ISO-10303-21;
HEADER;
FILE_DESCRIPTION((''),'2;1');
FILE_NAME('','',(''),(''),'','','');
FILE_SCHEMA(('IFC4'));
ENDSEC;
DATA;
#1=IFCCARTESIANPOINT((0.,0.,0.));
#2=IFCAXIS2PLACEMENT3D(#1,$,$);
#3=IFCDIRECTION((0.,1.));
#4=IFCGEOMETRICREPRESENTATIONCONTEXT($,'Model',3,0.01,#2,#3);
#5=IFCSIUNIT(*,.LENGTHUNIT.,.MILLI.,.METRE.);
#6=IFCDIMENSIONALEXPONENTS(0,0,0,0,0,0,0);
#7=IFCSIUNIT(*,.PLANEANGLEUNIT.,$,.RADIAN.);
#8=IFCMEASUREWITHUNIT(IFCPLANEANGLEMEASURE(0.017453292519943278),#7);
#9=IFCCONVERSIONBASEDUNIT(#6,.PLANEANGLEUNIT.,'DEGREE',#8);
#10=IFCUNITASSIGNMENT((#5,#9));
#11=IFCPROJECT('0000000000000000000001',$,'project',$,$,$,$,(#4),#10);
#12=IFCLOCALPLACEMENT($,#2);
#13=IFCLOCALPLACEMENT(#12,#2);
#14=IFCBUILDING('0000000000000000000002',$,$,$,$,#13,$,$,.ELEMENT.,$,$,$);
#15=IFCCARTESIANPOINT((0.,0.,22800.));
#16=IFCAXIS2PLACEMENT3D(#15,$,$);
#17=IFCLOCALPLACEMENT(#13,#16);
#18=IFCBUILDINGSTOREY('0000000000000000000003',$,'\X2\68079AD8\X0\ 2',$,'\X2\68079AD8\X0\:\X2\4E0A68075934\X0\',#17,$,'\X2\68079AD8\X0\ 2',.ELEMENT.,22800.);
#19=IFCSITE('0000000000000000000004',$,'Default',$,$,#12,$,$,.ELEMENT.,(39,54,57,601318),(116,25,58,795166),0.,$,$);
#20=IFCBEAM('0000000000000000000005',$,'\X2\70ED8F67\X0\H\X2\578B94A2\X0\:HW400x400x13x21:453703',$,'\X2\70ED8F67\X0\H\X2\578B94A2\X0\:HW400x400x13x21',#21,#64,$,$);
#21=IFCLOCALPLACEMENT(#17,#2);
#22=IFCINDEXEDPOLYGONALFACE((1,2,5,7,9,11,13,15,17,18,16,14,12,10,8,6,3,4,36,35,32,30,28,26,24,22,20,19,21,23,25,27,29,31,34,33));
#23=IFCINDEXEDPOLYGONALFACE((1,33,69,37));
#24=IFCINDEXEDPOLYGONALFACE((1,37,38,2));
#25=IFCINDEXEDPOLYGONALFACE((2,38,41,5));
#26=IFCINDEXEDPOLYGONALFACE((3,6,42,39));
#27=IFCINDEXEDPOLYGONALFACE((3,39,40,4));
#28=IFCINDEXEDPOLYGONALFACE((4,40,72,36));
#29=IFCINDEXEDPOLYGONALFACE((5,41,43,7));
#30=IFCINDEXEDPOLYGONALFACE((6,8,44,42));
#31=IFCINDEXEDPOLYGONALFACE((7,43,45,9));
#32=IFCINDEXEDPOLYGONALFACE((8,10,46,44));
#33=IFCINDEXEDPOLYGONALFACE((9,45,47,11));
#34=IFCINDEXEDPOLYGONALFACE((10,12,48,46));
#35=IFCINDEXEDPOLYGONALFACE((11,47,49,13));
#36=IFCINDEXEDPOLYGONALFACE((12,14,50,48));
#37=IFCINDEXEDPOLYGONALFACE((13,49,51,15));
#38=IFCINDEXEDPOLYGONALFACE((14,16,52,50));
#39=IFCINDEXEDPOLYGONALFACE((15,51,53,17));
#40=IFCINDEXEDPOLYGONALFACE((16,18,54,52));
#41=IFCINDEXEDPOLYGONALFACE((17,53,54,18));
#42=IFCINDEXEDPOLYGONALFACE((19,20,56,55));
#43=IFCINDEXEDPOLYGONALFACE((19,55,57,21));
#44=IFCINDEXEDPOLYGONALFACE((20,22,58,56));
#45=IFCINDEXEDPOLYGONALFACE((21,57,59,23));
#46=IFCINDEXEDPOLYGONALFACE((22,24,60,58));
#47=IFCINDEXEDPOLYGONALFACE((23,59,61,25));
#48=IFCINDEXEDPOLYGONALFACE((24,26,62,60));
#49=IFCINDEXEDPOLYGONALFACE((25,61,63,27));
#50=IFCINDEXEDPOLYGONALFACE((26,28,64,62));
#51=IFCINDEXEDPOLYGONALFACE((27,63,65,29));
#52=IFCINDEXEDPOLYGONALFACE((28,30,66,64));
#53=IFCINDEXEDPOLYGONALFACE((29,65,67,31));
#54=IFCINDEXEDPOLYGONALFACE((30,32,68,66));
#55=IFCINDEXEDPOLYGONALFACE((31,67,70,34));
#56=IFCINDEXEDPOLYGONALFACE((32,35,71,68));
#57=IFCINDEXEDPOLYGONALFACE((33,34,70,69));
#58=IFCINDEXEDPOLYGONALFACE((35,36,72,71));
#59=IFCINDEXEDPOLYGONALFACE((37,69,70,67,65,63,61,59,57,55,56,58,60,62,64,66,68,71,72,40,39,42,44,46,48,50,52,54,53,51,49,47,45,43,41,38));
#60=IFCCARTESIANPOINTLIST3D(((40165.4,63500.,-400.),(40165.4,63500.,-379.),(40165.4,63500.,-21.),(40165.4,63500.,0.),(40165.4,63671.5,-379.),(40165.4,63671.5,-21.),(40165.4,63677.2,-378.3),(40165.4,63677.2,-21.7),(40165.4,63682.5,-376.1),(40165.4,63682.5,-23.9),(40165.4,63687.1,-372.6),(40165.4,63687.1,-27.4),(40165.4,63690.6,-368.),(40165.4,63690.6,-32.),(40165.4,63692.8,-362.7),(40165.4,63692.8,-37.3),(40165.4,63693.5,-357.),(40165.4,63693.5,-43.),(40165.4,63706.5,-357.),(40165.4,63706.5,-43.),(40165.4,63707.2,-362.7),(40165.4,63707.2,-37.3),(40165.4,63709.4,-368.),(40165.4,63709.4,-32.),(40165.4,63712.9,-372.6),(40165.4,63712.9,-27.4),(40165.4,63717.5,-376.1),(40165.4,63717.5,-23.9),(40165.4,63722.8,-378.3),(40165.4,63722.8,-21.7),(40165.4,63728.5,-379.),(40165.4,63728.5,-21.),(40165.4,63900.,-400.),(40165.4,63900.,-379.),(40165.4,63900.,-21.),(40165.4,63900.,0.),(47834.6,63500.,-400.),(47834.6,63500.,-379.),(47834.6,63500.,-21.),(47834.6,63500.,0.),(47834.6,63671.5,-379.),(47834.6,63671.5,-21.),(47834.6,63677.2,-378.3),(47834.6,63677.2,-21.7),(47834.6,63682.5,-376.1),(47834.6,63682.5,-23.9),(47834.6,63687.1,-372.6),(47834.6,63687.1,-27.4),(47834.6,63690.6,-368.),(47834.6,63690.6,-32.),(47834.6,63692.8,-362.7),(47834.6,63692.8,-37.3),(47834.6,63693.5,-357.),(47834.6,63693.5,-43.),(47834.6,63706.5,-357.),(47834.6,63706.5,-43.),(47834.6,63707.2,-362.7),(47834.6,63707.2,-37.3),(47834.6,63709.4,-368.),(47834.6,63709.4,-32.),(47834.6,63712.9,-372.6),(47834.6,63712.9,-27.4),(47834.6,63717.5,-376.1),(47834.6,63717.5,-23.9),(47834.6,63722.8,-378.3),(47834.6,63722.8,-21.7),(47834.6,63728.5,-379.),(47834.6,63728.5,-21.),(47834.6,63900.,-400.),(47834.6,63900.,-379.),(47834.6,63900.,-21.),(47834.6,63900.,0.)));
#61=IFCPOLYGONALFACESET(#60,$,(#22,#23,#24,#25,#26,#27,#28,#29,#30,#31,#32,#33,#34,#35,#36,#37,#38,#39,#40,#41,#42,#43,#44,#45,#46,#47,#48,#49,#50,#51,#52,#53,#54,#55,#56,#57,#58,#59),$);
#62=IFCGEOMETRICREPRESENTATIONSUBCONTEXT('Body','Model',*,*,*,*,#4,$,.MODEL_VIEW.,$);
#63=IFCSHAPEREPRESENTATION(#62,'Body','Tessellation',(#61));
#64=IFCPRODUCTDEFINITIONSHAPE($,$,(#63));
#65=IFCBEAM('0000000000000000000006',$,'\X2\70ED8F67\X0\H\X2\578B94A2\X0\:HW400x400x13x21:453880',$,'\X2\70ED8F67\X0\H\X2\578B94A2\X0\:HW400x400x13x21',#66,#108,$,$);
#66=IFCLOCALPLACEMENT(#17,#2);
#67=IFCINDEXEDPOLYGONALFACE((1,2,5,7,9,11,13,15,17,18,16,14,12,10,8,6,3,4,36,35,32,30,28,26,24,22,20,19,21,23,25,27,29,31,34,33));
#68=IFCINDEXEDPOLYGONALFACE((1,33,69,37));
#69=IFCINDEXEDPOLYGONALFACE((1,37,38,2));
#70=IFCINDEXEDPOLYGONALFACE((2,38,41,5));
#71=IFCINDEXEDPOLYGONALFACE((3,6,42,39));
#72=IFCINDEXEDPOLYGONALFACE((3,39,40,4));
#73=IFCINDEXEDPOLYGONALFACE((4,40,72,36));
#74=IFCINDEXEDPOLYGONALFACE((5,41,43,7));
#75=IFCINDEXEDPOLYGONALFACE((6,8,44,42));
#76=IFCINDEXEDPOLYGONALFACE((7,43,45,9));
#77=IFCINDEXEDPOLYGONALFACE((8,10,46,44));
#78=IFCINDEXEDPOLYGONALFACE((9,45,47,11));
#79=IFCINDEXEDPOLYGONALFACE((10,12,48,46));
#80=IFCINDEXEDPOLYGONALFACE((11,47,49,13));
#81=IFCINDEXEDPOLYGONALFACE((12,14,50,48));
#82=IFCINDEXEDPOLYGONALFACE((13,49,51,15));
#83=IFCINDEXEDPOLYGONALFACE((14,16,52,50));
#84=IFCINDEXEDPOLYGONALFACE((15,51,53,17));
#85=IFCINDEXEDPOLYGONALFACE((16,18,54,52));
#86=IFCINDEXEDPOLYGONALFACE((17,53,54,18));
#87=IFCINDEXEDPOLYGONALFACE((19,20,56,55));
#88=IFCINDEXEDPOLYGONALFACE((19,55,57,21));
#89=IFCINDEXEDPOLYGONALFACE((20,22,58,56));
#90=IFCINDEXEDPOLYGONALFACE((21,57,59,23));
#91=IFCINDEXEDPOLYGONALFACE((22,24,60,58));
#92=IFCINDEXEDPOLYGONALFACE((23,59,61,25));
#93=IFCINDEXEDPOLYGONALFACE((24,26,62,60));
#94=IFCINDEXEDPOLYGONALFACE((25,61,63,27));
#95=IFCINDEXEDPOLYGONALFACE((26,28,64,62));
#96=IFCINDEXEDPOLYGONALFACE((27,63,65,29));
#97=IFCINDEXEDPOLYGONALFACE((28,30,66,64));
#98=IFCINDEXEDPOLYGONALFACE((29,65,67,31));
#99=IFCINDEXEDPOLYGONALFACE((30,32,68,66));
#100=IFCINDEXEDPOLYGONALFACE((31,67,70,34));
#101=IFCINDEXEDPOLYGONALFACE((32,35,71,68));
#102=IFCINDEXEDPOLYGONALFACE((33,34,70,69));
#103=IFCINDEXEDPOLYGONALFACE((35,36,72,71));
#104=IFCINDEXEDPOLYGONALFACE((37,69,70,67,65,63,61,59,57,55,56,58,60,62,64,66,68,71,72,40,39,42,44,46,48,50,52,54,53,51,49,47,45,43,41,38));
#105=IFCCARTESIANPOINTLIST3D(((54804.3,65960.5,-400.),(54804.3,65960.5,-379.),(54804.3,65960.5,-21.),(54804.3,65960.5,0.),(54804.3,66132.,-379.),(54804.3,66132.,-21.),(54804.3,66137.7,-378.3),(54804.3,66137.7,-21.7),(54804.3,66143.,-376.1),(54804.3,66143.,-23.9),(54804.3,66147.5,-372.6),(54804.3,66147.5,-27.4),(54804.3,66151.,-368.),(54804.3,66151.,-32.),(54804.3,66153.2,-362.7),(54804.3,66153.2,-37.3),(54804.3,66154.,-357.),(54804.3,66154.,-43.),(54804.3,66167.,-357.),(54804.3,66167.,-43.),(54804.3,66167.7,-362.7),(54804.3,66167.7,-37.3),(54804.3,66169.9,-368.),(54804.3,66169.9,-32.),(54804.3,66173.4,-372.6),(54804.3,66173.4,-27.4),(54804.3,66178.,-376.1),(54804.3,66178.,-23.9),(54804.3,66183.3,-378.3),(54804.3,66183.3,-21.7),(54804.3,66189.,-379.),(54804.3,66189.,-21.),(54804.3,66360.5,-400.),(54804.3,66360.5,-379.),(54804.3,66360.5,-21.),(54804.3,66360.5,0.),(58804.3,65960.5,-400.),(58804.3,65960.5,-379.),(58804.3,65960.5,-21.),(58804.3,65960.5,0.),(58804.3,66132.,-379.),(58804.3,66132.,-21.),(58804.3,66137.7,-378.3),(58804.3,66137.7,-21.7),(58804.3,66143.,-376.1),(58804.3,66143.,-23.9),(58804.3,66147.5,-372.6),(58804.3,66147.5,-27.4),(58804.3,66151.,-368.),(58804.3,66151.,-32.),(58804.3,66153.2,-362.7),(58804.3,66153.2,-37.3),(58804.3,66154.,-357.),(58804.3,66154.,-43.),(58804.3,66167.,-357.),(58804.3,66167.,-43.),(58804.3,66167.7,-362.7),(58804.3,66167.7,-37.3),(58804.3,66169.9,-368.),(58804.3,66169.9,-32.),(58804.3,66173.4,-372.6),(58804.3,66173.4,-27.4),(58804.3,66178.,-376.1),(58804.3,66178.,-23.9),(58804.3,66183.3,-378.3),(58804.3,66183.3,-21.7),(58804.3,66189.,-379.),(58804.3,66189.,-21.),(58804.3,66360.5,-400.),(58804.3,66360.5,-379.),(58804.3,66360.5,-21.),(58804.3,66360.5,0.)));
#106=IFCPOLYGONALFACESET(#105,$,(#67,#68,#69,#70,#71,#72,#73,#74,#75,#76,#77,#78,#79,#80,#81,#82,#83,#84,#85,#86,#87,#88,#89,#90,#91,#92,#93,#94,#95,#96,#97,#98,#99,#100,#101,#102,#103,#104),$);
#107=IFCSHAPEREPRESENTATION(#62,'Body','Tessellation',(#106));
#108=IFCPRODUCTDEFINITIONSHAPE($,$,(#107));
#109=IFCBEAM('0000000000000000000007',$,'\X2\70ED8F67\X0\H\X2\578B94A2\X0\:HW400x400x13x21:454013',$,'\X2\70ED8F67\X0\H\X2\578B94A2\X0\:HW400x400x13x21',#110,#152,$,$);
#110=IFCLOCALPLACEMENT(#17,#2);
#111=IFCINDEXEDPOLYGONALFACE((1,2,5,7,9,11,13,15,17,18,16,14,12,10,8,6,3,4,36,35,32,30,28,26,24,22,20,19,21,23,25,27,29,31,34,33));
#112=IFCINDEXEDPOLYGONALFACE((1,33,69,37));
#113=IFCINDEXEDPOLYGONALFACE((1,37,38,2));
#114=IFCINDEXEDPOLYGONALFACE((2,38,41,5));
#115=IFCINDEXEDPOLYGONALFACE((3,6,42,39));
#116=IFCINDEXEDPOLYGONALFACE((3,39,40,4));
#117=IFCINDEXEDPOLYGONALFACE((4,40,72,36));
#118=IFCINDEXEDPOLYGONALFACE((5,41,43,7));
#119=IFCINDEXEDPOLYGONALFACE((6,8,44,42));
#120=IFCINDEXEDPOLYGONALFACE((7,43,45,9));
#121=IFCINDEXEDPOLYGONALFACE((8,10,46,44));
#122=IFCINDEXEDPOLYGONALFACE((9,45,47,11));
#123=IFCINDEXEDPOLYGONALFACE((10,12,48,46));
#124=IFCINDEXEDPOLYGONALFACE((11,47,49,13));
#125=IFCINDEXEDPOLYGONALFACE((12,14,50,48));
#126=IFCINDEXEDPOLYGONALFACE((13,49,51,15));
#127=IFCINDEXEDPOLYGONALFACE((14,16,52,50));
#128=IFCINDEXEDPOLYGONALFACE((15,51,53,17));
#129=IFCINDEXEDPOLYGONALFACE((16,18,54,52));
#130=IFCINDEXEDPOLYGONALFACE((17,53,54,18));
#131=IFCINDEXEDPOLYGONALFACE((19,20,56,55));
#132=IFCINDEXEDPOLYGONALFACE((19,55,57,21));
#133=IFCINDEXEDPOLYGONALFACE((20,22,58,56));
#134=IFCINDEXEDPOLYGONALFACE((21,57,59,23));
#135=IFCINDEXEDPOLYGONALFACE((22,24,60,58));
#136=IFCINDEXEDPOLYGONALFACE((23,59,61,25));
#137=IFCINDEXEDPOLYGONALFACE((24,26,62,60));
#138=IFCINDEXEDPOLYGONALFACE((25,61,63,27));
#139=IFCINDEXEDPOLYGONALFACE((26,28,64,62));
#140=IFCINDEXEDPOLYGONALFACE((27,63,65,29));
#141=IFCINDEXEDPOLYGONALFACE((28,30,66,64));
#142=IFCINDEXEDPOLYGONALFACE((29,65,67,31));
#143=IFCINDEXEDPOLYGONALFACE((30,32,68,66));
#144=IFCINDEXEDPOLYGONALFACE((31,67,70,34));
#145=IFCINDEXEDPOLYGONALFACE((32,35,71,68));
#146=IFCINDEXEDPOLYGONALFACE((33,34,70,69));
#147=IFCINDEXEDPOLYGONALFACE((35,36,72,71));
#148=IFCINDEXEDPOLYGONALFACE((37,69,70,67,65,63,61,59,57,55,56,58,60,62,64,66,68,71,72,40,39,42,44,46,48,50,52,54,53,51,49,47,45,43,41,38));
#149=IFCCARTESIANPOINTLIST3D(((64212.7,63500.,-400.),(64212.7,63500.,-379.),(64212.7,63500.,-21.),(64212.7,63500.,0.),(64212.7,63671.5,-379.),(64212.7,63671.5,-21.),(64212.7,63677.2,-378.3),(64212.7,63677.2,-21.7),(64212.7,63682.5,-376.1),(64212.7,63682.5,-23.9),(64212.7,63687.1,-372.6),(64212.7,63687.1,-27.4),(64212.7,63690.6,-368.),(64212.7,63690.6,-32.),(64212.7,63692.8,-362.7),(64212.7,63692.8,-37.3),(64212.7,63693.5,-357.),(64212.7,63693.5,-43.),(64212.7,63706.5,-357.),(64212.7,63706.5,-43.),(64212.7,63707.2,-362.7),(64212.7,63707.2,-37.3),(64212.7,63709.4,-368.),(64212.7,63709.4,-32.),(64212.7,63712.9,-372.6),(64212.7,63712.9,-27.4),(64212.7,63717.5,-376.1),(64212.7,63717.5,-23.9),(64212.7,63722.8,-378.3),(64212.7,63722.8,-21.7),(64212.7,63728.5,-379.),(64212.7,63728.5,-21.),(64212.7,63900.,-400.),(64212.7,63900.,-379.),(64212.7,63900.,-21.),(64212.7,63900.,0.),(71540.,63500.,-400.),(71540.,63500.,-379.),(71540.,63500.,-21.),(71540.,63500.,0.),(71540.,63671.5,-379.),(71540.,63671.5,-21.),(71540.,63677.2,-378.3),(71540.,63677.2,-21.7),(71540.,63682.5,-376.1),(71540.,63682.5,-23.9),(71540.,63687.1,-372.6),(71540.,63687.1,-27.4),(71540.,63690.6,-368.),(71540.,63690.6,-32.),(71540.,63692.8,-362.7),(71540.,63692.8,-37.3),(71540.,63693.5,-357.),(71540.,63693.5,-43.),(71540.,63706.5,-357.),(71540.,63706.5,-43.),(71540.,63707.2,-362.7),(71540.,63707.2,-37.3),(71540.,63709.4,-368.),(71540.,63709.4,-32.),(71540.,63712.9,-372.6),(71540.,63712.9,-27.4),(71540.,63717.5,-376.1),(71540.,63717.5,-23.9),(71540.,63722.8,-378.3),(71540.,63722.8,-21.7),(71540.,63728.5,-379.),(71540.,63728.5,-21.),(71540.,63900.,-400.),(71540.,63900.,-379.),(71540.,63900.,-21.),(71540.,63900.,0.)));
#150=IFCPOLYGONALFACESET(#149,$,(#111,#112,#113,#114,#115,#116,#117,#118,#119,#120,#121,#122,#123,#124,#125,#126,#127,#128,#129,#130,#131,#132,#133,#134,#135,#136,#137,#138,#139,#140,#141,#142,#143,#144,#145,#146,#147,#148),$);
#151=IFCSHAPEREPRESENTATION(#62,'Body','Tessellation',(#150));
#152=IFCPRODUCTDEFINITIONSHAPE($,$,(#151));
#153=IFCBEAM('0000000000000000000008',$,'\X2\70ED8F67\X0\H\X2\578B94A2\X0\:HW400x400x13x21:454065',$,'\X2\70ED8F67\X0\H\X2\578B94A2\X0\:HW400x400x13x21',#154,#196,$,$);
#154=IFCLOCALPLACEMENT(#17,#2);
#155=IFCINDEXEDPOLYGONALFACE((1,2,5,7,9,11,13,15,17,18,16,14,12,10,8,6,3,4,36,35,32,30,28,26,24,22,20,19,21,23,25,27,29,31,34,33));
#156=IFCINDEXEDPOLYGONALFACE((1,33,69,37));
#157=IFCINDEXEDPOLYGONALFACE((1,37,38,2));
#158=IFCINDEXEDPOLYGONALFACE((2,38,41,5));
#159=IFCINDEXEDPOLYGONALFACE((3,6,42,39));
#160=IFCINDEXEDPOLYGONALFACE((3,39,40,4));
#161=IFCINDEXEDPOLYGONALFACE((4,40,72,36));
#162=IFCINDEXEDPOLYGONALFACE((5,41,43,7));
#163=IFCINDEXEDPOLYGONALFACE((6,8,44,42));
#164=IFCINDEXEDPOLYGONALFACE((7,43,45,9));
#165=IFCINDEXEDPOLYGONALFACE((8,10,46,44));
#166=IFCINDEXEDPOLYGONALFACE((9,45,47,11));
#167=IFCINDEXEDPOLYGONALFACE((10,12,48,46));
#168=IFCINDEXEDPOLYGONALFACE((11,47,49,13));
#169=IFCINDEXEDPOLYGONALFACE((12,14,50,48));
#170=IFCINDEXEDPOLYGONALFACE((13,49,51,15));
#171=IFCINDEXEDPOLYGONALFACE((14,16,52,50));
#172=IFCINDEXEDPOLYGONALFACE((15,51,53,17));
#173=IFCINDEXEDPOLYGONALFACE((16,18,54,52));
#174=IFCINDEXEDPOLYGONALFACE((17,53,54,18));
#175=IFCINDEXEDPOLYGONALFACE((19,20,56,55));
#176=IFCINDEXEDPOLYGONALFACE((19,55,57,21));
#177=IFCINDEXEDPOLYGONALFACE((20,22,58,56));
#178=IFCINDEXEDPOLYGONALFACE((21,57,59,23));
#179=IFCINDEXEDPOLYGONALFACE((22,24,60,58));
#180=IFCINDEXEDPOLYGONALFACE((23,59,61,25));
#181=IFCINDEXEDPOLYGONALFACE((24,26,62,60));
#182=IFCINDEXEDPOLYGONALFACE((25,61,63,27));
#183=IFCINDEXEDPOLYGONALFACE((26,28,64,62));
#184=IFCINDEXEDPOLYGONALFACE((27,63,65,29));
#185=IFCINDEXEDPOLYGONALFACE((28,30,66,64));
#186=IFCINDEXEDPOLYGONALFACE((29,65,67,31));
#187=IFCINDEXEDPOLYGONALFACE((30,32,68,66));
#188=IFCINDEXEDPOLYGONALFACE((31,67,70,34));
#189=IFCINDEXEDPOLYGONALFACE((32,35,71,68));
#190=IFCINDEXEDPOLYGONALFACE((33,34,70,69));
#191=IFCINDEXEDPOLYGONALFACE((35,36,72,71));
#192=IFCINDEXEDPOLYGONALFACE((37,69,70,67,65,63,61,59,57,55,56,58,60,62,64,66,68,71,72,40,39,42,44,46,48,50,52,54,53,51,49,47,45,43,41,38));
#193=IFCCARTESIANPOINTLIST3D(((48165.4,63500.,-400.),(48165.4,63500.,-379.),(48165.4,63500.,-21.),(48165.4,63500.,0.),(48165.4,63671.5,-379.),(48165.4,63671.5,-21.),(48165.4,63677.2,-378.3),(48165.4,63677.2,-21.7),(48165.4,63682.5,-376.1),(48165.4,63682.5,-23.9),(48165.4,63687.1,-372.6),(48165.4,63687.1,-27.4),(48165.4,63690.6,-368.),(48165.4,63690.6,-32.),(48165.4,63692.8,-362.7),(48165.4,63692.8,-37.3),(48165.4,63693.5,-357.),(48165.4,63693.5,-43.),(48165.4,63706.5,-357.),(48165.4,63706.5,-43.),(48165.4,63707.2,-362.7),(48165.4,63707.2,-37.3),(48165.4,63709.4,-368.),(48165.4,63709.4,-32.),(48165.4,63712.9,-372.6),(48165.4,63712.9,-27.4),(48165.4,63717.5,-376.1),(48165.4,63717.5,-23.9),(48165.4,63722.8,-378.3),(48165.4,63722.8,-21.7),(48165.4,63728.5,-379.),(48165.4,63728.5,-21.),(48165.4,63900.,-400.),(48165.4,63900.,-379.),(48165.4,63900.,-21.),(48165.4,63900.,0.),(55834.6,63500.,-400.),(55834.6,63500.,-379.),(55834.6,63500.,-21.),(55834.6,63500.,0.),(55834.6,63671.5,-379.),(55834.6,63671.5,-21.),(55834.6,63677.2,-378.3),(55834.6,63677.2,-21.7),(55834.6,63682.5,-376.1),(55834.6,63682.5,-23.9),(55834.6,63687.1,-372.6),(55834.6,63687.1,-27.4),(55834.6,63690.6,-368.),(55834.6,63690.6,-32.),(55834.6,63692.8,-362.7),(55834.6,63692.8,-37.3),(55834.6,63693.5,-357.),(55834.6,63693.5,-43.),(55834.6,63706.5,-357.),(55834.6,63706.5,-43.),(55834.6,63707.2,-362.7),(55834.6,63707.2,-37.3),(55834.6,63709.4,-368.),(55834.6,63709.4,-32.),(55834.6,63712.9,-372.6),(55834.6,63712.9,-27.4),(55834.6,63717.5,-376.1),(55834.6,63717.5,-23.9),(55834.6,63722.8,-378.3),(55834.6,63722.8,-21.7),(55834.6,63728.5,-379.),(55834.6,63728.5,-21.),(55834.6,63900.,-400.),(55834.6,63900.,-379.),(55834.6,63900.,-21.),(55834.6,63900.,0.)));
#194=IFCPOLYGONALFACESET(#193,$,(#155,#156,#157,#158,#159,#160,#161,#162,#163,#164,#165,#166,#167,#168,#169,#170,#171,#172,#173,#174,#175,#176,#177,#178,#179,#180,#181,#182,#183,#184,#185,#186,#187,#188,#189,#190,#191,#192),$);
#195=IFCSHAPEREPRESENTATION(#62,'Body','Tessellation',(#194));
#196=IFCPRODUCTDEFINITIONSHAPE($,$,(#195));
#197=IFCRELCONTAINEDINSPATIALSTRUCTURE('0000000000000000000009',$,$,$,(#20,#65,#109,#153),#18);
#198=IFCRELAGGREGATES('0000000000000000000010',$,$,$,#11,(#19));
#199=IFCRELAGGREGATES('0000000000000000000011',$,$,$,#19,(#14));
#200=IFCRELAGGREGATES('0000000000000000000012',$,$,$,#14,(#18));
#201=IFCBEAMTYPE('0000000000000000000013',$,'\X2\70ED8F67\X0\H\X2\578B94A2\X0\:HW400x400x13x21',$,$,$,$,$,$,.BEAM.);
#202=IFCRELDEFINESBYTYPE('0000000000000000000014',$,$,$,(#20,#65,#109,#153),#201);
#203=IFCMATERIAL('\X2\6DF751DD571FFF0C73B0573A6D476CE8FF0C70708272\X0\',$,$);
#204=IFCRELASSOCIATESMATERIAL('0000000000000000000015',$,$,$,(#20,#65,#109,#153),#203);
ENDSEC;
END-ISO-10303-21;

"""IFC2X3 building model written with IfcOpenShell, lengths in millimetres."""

from ifc_helpers import new_model, entity, si_unit, converted_unit, direction, frame, frame_2d, origin, place, context, subcontext, project, spatial, i_section, extrude, material, type_object, element, save


model = new_model("IFC2X3")

# Units and contexts
model_context = context("Model", 3, precision=0.01, world=origin(), true_north=direction((0.0, 1.0)))
body_context = subcontext(model_context, "Body", "Model", "MODEL_VIEW")
ifc_project = project(units=[si_unit("LENGTHUNIT", "METRE", prefix="MILLI"), converted_unit("PLANEANGLEUNIT", "DEGREE", entity("IfcPlaneAngleMeasure", 0.017453292519943278), si_unit("PLANEANGLEUNIT", "RADIAN"), dimensions=[0, 0, 0, 0, 0, 0, 0])], contexts=[model_context])

# Site, building, storey
site_placement = place(None, origin())
site = spatial("IfcSite", under=ifc_project, at=site_placement, Name="Default", CompositionType="ELEMENT", RefLatitude=(39, 54, 57, 601318), RefLongitude=(116, 25, 58, 795166), RefElevation=0.0)
building_placement = place(site_placement, origin())
building = spatial("IfcBuilding", under=site, at=building_placement, CompositionType="ELEMENT")
storey_placement = place(building_placement, frame((0.0, 0.0, 22800.0)))
storey = spatial("IfcBuildingStorey", under=building, at=storey_placement, Name="标高 2", ObjectType="标高:上标头", LongName="标高 2", CompositionType="ELEMENT", Elevation=22800.0)

# Beams
ifc_material = material(Name="混凝土，现场浇注，灰色")
beam_type = type_object("IfcBeamType", Name="热轧H型钢:HW400x400x13x21", PredefinedType="BEAM")
beam_1_placement = place(storey_placement, frame((48000.0, 63700.0, 0.0), z_axis=(0.0, 0.0, 1.0), x_axis=(-1.0, 0.0, 0.0)))
element("IfcBeam", 1, at=beam_1_placement, inside=storey, type_object=beam_type, material=ifc_material, Name="热轧H型钢:HW400x400x13x21:453703", ObjectType="热轧H型钢:HW400x400x13x21", context=body_context, shape_type="SweptSolid", body=[
    extrude(i_section(OverallWidth=400.0, OverallDepth=400.0, WebThickness=13.0, FlangeThickness=21.0, FilletRadius=22.0, at=frame_2d((0.0, 0.0), x_axis=(0.0, 1.0))), frame((165.4, 0.0, -200.0), z_axis=(1.0, 0.0, 0.0), x_axis=(0.0, 0.0, -1.0)), (0.0, 0.0, 1.0), 7669.2),
])
beam_2_placement = place(storey_placement, frame((54804.3, 66160.5, 0.0)))
element("IfcBeam", 2, at=beam_2_placement, inside=storey, type_object=beam_type, material=ifc_material, Name="热轧H型钢:HW400x400x13x21:453880", ObjectType="热轧H型钢:HW400x400x13x21", context=body_context, shape_type="SweptSolid", body=[
    extrude(i_section(OverallWidth=400.0, OverallDepth=400.0, WebThickness=13.0, FlangeThickness=21.0, FilletRadius=22.0, at=frame_2d((0.0, 0.0), x_axis=(0.0, 1.0))), frame((0.0, 0.0, -200.0), z_axis=(1.0, 0.0, 0.0), x_axis=(0.0, 0.0, -1.0)), (0.0, 0.0, 1.0), 4000.0),
])
beam_3_placement = place(storey_placement, frame((64000.0, 63700.0, 0.0)))
element("IfcBeam", 3, at=beam_3_placement, inside=storey, type_object=beam_type, material=ifc_material, Name="热轧H型钢:HW400x400x13x21:454013", ObjectType="热轧H型钢:HW400x400x13x21", context=body_context, shape_type="SweptSolid", body=[
    extrude(i_section(OverallWidth=400.0, OverallDepth=400.0, WebThickness=13.0, FlangeThickness=21.0, FilletRadius=22.0, at=frame_2d((0.0, 0.0), x_axis=(0.0, 1.0))), frame((212.7, 0.0, -200.0), z_axis=(1.0, 0.0, 0.0), x_axis=(0.0, 0.0, -1.0)), (0.0, 0.0, 1.0), 7327.3),
])
beam_4_placement = place(storey_placement, frame((48000.0, 63700.0, 0.0)))
element("IfcBeam", 4, at=beam_4_placement, inside=storey, type_object=beam_type, material=ifc_material, Name="热轧H型钢:HW400x400x13x21:454065", ObjectType="热轧H型钢:HW400x400x13x21", context=body_context, shape_type="SweptSolid", body=[
    extrude(i_section(OverallWidth=400.0, OverallDepth=400.0, WebThickness=13.0, FlangeThickness=21.0, FilletRadius=22.0, at=frame_2d((0.0, 0.0), x_axis=(0.0, 1.0))), frame((165.4, 0.0, -200.0), z_axis=(1.0, 0.0, 0.0), x_axis=(0.0, 0.0, -1.0)), (0.0, 0.0, 1.0), 7669.2),
])

save(model, "model.ifc")
